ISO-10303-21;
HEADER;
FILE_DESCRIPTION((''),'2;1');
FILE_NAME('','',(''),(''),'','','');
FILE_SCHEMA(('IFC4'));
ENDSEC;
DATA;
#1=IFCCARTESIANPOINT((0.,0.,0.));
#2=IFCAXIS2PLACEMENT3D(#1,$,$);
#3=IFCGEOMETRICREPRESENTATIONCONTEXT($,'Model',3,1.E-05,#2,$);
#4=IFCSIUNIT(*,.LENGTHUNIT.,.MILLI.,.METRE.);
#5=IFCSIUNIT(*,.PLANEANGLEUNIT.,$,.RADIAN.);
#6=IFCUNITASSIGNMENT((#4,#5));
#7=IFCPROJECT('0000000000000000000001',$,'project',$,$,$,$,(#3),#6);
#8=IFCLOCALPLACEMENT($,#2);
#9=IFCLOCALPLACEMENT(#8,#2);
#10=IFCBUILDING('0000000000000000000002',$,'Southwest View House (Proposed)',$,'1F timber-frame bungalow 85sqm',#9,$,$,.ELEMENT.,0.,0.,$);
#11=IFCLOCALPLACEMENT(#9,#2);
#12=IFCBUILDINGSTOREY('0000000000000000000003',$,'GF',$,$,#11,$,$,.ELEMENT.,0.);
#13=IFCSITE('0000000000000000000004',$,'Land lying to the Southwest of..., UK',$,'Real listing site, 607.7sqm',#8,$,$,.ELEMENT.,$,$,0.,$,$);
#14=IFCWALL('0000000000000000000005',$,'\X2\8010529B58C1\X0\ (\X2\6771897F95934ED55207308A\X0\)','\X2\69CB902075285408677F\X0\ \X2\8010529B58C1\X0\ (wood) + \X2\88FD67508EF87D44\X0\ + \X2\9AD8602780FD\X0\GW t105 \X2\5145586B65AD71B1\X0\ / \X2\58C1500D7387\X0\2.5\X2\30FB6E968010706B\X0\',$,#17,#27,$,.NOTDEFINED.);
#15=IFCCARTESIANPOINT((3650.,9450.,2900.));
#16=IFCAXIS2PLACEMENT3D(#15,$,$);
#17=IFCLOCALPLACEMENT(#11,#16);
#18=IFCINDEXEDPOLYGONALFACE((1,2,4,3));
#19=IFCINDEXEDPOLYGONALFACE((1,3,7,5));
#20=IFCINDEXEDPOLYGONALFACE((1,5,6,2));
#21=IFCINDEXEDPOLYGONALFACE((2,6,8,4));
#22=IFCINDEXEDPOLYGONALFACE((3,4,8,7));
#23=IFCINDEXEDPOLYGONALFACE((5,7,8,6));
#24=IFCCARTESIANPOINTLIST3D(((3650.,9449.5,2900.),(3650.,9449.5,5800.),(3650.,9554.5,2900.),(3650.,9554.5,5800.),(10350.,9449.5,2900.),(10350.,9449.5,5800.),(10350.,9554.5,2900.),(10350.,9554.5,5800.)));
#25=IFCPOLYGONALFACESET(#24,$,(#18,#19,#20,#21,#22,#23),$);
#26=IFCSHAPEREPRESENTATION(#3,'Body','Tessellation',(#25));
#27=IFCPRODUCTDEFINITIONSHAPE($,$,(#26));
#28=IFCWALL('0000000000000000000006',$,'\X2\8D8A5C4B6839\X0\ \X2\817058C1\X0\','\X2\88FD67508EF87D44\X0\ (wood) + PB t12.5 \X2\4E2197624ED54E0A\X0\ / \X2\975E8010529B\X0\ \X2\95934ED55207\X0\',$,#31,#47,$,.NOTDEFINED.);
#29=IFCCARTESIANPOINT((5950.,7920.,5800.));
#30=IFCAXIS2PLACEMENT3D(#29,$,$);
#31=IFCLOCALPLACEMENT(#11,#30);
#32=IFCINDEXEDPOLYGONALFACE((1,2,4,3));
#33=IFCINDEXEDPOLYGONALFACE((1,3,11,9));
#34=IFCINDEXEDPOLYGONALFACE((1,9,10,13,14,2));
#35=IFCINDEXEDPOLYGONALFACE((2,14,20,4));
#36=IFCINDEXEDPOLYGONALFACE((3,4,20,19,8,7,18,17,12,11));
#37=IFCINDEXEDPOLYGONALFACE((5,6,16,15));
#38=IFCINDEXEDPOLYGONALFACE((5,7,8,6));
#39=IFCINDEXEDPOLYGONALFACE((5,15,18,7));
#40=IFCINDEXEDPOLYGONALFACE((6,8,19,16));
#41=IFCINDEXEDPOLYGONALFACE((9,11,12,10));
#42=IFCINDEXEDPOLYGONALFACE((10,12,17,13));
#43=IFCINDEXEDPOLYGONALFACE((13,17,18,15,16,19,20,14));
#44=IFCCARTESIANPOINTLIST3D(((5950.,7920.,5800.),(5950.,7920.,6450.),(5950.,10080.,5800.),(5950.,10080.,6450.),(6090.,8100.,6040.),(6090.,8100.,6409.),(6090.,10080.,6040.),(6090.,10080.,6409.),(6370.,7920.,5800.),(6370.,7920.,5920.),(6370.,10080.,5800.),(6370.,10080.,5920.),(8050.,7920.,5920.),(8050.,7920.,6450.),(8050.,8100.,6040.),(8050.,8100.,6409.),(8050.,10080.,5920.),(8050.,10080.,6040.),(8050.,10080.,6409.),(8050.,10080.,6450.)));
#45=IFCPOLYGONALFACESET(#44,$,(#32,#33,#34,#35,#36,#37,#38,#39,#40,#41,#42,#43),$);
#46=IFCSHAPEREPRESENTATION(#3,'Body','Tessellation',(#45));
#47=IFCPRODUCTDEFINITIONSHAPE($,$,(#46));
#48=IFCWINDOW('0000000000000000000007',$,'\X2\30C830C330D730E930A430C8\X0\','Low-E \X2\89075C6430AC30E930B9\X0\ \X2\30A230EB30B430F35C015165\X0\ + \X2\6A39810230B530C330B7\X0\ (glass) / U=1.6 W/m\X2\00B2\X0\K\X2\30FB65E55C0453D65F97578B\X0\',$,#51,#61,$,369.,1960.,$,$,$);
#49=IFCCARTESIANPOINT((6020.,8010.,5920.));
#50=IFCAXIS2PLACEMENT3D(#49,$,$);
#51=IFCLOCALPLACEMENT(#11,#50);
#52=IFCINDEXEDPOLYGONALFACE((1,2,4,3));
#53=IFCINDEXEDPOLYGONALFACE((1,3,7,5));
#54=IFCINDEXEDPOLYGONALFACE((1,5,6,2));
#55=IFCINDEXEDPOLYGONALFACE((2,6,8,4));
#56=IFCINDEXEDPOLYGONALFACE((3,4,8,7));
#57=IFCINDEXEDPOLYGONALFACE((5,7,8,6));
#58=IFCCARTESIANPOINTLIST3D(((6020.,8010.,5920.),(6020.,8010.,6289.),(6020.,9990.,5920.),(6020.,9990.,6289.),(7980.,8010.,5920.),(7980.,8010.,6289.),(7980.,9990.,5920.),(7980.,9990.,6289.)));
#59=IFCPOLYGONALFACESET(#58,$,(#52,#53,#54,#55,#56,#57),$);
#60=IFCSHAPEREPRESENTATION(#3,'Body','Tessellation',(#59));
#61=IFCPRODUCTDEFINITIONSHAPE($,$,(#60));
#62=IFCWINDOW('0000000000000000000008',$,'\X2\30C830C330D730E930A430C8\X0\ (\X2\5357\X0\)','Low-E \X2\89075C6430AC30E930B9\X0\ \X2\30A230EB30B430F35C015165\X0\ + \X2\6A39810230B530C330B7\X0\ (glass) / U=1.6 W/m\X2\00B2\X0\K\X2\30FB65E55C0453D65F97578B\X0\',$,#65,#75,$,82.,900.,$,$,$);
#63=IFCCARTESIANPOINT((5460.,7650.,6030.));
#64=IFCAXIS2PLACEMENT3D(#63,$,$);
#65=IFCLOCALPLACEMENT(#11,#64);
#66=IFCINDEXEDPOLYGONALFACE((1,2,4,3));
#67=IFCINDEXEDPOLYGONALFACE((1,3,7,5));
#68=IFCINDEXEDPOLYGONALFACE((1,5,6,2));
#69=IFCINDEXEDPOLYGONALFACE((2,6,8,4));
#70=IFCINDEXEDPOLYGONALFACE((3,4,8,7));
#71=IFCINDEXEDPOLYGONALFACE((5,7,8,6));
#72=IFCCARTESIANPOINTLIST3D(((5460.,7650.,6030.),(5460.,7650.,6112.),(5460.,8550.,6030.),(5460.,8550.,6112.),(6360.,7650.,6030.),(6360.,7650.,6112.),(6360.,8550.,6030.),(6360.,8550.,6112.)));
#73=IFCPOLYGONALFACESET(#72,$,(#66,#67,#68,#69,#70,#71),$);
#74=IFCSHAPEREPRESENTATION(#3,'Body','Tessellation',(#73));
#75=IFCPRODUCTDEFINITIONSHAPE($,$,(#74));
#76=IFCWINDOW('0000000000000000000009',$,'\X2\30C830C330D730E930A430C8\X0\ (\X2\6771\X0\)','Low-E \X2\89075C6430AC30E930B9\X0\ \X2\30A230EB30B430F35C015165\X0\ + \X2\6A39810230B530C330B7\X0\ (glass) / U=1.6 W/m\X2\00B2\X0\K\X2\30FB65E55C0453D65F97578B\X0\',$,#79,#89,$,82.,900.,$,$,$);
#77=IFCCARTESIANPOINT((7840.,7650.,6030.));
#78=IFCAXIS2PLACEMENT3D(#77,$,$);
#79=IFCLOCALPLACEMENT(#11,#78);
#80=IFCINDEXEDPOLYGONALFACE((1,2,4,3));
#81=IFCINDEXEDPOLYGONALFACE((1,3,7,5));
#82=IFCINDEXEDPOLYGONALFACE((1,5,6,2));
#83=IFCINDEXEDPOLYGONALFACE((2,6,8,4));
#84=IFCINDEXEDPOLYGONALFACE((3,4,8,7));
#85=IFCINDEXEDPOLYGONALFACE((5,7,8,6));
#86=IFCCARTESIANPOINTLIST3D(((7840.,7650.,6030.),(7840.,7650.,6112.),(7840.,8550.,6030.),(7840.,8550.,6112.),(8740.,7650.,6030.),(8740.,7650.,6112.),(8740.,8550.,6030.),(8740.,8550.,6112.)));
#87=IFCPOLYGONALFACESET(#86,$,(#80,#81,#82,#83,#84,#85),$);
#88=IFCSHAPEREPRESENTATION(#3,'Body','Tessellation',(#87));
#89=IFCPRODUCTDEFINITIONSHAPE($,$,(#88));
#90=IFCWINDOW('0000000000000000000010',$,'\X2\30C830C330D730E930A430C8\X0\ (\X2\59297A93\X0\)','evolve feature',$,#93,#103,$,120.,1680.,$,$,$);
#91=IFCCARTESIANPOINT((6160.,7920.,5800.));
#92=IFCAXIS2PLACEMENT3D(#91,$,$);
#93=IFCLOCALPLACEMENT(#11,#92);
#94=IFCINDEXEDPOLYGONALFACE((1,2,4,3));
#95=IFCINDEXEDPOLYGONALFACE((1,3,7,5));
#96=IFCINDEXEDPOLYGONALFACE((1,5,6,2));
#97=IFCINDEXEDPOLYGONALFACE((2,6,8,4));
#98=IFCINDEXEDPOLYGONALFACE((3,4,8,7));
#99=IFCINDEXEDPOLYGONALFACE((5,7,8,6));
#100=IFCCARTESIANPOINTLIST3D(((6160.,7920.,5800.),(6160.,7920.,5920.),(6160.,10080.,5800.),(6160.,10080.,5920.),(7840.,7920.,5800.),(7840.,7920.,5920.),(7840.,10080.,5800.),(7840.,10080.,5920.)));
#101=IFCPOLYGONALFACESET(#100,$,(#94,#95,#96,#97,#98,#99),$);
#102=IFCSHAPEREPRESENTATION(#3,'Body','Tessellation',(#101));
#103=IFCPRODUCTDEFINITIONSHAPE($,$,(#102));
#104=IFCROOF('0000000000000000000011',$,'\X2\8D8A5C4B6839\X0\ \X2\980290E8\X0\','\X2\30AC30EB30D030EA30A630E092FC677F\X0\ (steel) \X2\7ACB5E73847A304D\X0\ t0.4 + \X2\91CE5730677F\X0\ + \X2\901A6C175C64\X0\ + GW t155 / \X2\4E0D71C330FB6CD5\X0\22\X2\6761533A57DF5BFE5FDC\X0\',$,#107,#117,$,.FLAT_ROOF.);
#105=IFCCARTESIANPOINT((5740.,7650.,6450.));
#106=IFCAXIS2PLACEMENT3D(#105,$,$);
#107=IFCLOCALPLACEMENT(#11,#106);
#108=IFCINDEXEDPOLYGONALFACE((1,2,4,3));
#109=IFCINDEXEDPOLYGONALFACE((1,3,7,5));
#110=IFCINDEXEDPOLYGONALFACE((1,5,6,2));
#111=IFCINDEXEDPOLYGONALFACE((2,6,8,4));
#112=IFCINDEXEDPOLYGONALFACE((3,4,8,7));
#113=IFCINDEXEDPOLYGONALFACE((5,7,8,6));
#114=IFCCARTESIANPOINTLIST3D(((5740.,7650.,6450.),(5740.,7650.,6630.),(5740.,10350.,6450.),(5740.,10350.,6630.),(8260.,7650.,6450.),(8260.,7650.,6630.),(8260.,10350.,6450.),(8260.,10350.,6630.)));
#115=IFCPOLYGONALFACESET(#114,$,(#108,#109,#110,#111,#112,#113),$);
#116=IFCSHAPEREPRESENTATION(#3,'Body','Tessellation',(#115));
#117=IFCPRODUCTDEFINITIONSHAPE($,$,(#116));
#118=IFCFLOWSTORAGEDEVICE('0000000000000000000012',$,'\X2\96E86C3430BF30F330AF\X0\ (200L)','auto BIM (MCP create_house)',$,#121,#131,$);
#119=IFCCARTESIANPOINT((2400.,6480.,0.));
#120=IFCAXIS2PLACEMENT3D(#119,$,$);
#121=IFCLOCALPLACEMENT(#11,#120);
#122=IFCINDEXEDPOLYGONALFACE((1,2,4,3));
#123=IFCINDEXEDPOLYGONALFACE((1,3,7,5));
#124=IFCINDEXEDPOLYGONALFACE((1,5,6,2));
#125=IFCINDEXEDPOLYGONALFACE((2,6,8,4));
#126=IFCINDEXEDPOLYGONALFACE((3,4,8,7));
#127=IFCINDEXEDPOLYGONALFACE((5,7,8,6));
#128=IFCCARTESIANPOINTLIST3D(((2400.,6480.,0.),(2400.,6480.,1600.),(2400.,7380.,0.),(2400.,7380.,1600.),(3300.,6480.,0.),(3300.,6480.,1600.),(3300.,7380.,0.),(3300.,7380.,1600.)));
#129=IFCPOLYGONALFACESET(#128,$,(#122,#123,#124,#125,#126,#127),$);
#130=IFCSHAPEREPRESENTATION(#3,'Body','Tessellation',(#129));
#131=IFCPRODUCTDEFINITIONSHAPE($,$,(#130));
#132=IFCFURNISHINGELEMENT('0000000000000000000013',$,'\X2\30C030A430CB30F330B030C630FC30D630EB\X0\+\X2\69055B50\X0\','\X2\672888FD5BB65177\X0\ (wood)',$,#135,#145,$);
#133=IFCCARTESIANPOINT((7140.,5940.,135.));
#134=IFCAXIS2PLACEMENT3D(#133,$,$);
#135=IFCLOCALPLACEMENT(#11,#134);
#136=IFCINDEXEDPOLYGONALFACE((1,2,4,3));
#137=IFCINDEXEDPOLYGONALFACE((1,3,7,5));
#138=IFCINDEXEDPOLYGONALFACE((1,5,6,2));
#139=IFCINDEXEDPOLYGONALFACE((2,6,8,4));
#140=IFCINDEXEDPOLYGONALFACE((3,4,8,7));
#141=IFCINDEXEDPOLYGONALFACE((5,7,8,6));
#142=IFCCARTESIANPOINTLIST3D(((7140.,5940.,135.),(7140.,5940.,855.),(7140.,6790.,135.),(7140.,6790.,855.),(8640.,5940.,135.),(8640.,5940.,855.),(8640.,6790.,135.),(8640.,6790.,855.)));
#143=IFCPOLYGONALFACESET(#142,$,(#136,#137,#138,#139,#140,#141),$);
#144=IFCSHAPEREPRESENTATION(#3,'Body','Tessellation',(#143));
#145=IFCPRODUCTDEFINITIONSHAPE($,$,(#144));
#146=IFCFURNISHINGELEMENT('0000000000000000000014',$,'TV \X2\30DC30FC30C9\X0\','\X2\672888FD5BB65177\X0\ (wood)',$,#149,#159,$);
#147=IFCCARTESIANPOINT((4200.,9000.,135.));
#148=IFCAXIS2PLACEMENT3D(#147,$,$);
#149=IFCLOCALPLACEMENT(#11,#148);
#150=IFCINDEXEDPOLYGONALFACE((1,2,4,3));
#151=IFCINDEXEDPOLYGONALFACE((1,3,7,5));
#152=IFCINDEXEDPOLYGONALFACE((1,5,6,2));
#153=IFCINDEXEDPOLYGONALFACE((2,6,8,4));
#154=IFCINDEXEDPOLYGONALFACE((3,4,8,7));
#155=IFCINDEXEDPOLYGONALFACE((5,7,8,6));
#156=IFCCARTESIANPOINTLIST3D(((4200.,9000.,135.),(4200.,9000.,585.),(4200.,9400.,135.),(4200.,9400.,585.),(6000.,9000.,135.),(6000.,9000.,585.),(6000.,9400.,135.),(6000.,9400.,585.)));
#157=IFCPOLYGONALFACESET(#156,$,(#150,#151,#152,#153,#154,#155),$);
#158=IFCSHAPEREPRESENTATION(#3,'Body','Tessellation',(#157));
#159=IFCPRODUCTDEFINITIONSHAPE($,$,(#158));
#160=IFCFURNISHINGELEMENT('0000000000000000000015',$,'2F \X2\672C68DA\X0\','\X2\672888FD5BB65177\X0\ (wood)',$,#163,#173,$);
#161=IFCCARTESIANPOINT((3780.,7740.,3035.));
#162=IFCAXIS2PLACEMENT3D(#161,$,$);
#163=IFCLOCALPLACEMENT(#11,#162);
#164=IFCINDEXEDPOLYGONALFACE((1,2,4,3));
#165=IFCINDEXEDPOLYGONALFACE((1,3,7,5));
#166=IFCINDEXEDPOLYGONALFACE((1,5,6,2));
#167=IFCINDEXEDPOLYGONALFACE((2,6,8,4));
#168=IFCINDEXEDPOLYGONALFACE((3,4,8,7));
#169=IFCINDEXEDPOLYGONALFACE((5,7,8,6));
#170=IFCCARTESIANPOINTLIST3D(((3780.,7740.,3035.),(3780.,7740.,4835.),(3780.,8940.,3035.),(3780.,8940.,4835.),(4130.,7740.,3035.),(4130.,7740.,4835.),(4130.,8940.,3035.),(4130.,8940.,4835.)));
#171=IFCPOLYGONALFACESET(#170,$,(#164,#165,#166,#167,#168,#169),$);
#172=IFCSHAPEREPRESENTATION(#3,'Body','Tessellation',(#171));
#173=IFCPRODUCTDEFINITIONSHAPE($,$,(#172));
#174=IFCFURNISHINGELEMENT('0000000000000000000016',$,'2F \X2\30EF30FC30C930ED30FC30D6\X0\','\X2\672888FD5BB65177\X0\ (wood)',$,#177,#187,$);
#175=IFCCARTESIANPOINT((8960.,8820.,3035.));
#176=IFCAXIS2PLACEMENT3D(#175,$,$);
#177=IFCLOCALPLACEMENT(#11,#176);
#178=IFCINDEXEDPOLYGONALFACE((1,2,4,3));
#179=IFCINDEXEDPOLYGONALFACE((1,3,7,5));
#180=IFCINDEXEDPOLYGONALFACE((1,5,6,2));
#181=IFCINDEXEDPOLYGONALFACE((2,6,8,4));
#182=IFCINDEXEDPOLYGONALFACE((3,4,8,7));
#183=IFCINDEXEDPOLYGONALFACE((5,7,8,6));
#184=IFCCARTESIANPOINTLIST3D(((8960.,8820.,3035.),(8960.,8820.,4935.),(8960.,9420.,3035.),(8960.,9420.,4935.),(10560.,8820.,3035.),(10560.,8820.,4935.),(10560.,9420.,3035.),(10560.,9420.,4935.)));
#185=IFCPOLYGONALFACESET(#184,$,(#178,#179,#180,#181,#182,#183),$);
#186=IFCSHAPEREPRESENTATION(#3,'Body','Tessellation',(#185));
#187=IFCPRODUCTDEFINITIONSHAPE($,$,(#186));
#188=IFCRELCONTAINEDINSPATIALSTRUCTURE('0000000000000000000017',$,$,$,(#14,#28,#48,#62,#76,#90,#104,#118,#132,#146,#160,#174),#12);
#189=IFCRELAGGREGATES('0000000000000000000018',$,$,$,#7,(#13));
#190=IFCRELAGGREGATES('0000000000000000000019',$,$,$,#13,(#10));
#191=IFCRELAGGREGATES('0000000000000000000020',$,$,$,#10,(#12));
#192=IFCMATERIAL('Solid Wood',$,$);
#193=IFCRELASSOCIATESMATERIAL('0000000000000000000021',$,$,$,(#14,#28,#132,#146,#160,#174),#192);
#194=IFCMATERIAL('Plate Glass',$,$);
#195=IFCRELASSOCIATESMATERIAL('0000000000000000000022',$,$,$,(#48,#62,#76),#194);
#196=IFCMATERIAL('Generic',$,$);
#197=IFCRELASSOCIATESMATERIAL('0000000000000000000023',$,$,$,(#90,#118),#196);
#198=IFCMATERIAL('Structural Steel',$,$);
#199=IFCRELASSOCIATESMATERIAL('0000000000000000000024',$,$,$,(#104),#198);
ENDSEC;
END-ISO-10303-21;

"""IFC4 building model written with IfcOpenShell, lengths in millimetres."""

from ifc_helpers import new_model, si_unit, frame, frame_2d, origin, place, context, project, spatial, rectangle, extrude, material, element, fill, save


model = new_model("IFC4")

# Units and contexts
model_context = context("Model", 3, precision=1e-05, world=origin())
ifc_project = project(units=[si_unit("LENGTHUNIT", "METRE", prefix="MILLI"), si_unit("PLANEANGLEUNIT", "RADIAN")], contexts=[model_context])

# Site, building, storey
site_placement = place(None, origin())
site = spatial("IfcSite", under=ifc_project, at=site_placement, Name="Land lying to the Southwest of..., UK", ObjectType="Real listing site, 607.7sqm", CompositionType="ELEMENT", RefElevation=0.0)
building_placement = place(site_placement, origin())
building = spatial("IfcBuilding", under=site, at=building_placement, Name="Southwest View House (Proposed)", ObjectType="1F timber-frame bungalow 85sqm", CompositionType="ELEMENT", ElevationOfRefHeight=0.0, ElevationOfTerrain=0.0)
storey_placement = place(building_placement, origin())
storey = spatial("IfcBuildingStorey", under=building, at=storey_placement, Name="GF", CompositionType="ELEMENT", Elevation=0.0)

# Wall
ifc_material_1 = material(Name="Solid Wood")
wall_1_placement = place(storey_placement, frame((3650.0, 9450.0, 2900.0)))
element("IfcWall", 1, at=wall_1_placement, inside=storey, material=ifc_material_1, Name="耐力壁 (東西間仕切り)", Description="構造用合板 耐力壁 (wood) + 製材軸組 + 高性能GW t105 充填断熱 / 壁倍率2.5・準耐火", PredefinedType="NOTDEFINED", context=model_context, shape_type="SweptSolid", body=[
    extrude(rectangle(XDim=6700.0, YDim=105.0, at=frame_2d((3350.0, 52.0))), frame((3650.0, 9450.0, 2900.0)), (0.0, 0.0, 1.0), 2900.0),
])

# Wall, openings, windows
wall_2_placement = place(storey_placement, frame((5950.0, 7920.0, 5800.0)))
wall_2 = element("IfcWall", 2, at=wall_2_placement, inside=storey, material=ifc_material_1, Name="越屋根 腰壁", Description="製材軸組 (wood) + PB t12.5 両面仕上 / 非耐力 間仕切", PredefinedType="NOTDEFINED", context=model_context, shape_type="SweptSolid", body=[
    extrude(rectangle(XDim=2100.0, YDim=2160.0, at=frame_2d((1050.0, 1080.0))), frame((5950.0, 7920.0, 5800.0)), (0.0, 0.0, 1.0), 650.0),
])
opening_1_placement = place(storey_placement, frame((6020.0, 8010.0, 5920.0)))
opening_1 = element("IfcOpeningElement", 3, at=opening_1_placement, cuts=wall_2, PredefinedType="NOTDEFINED", context=model_context, shape_type="SweptSolid", body=[
    extrude(rectangle(XDim=1960.0, YDim=1980.0, at=frame_2d((980.0, 990.0))), frame((6020.0, 8010.0, 5920.0)), (0.0, 0.0, 1.0), 369.0),
])
opening_2_placement = place(storey_placement, frame((5460.0, 7650.0, 6030.0)))
opening_2 = element("IfcOpeningElement", 4, at=opening_2_placement, cuts=wall_2, PredefinedType="NOTDEFINED", context=model_context, shape_type="SweptSolid", body=[
    extrude(rectangle(XDim=900.0, YDim=900.0, at=frame_2d((450.0, 450.0))), frame((5460.0, 7650.0, 6030.0)), (0.0, 0.0, 1.0), 82.0),
])
opening_3_placement = place(storey_placement, frame((7840.0, 7650.0, 6030.0)))
opening_3 = element("IfcOpeningElement", 5, at=opening_3_placement, cuts=wall_2, PredefinedType="NOTDEFINED", context=model_context, shape_type="SweptSolid", body=[
    extrude(rectangle(XDim=900.0, YDim=900.0, at=frame_2d((450.0, 450.0))), frame((7840.0, 7650.0, 6030.0)), (0.0, 0.0, 1.0), 82.0),
])
opening_4_placement = place(storey_placement, frame((6160.0, 7920.0, 5800.0)))
opening_4 = element("IfcOpeningElement", 6, at=opening_4_placement, cuts=wall_2, PredefinedType="NOTDEFINED", context=model_context, shape_type="SweptSolid", body=[
    extrude(rectangle(XDim=1680.0, YDim=2160.0, at=frame_2d((840.0, 1080.0))), frame((6160.0, 7920.0, 5800.0)), (0.0, 0.0, 1.0), 120.0),
])
ifc_material_2 = material(Name="Plate Glass")
window_1_placement = place(storey_placement, frame((6020.0, 8010.0, 5920.0)))
window_1 = element("IfcWindow", 7, at=window_1_placement, inside=storey, material=ifc_material_2, Name="トップライト", Description="Low-E 複層ガラス アルゴン封入 + 樹脂サッシ (glass) / U=1.6 W/m²K・日射取得型", OverallHeight=369.0, OverallWidth=1960.0, context=model_context, shape_type="SweptSolid", body=[
    extrude(rectangle(XDim=1960.0, YDim=1980.0, at=frame_2d((980.0, 990.0))), frame((6020.0, 8010.0, 5920.0)), (0.0, 0.0, 1.0), 369.0),
])
fill(opening_1, window_1)
window_2_placement = place(storey_placement, frame((5460.0, 7650.0, 6030.0)))
window_2 = element("IfcWindow", 8, at=window_2_placement, inside=storey, material=ifc_material_2, Name="トップライト (南)", Description="Low-E 複層ガラス アルゴン封入 + 樹脂サッシ (glass) / U=1.6 W/m²K・日射取得型", OverallHeight=82.0, OverallWidth=900.0, context=model_context, shape_type="SweptSolid", body=[
    extrude(rectangle(XDim=900.0, YDim=900.0, at=frame_2d((450.0, 450.0))), frame((5460.0, 7650.0, 6030.0)), (0.0, 0.0, 1.0), 82.0),
])
fill(opening_2, window_2)
window_3_placement = place(storey_placement, frame((7840.0, 7650.0, 6030.0)))
window_3 = element("IfcWindow", 9, at=window_3_placement, inside=storey, material=ifc_material_2, Name="トップライト (東)", Description="Low-E 複層ガラス アルゴン封入 + 樹脂サッシ (glass) / U=1.6 W/m²K・日射取得型", OverallHeight=82.0, OverallWidth=900.0, context=model_context, shape_type="SweptSolid", body=[
    extrude(rectangle(XDim=900.0, YDim=900.0, at=frame_2d((450.0, 450.0))), frame((7840.0, 7650.0, 6030.0)), (0.0, 0.0, 1.0), 82.0),
])
fill(opening_3, window_3)
ifc_material_3 = material(Name="Generic")
window_4_placement = place(storey_placement, frame((6160.0, 7920.0, 5800.0)))
window_4 = element("IfcWindow", 10, at=window_4_placement, inside=storey, material=ifc_material_3, Name="トップライト (天窓)", Description="evolve feature", OverallHeight=120.0, OverallWidth=1680.0, context=model_context, shape_type="SweptSolid", body=[
    extrude(rectangle(XDim=1680.0, YDim=2160.0, at=frame_2d((840.0, 1080.0))), frame((6160.0, 7920.0, 5800.0)), (0.0, 0.0, 1.0), 120.0),
])
fill(opening_4, window_4)

# Roof
ifc_material_4 = material(Name="Structural Steel")
roof_placement = place(storey_placement, frame((5740.0, 7650.0, 6450.0)))
element("IfcRoof", 11, at=roof_placement, inside=storey, material=ifc_material_4, Name="越屋根 頂部", Description="ガルバリウム鋼板 (steel) 立平葺き t0.4 + 野地板 + 通気層 + GW t155 / 不燃・法22条区域対応", PredefinedType="FLAT_ROOF", context=model_context, shape_type="SweptSolid", body=[
    extrude(rectangle(XDim=2520.0, YDim=2700.0, at=frame_2d((1260.0, 1350.0))), frame((5740.0, 7650.0, 6450.0)), (0.0, 0.0, 1.0), 180.0),
])

# Flow storage device
flow_storage_device_placement = place(storey_placement, frame((2400.0, 6480.0, 0.0)))
element("IfcFlowStorageDevice", 12, at=flow_storage_device_placement, inside=storey, material=ifc_material_3, Name="雨水タンク (200L)", Description="auto BIM (MCP create_house)", context=model_context, shape_type="SweptSolid", body=[
    extrude(rectangle(XDim=900.0, YDim=900.0, at=frame_2d((450.0, 450.0))), frame((2400.0, 6480.0, 0.0)), (0.0, 0.0, 1.0), 1600.0),
])

# Furnishing elements
furnishing_1_placement = place(storey_placement, frame((7140.0, 5940.0, 135.0)))
element("IfcFurnishingElement", 13, at=furnishing_1_placement, inside=storey, material=ifc_material_1, Name="ダイニングテーブル+椅子", Description="木製家具 (wood)", context=model_context, shape_type="SweptSolid", body=[
    extrude(rectangle(XDim=1500.0, YDim=850.0, at=frame_2d((750.0, 425.0))), frame((7140.0, 5940.0, 135.0)), (0.0, 0.0, 1.0), 720.0),
])
furnishing_2_placement = place(storey_placement, frame((4200.0, 9000.0, 135.0)))
element("IfcFurnishingElement", 14, at=furnishing_2_placement, inside=storey, material=ifc_material_1, Name="TV ボード", Description="木製家具 (wood)", context=model_context, shape_type="SweptSolid", body=[
    extrude(rectangle(XDim=1800.0, YDim=400.0, at=frame_2d((900.0, 200.0))), frame((4200.0, 9000.0, 135.0)), (0.0, 0.0, 1.0), 450.0),
])
furnishing_3_placement = place(storey_placement, frame((3780.0, 7740.0, 3035.0)))
element("IfcFurnishingElement", 15, at=furnishing_3_placement, inside=storey, material=ifc_material_1, Name="2F 本棚", Description="木製家具 (wood)", context=model_context, shape_type="SweptSolid", body=[
    extrude(rectangle(XDim=350.0, YDim=1200.0, at=frame_2d((175.0, 600.0))), frame((3780.0, 7740.0, 3035.0)), (0.0, 0.0, 1.0), 1800.0),
])
furnishing_4_placement = place(storey_placement, frame((8960.0, 8820.0, 3035.0)))
element("IfcFurnishingElement", 16, at=furnishing_4_placement, inside=storey, material=ifc_material_1, Name="2F ワードローブ", Description="木製家具 (wood)", context=model_context, shape_type="SweptSolid", body=[
    extrude(rectangle(XDim=1600.0, YDim=600.0, at=frame_2d((800.0, 300.0))), frame((8960.0, 8820.0, 3035.0)), (0.0, 0.0, 1.0), 1900.0),
])

save(model, "model.ifc")
